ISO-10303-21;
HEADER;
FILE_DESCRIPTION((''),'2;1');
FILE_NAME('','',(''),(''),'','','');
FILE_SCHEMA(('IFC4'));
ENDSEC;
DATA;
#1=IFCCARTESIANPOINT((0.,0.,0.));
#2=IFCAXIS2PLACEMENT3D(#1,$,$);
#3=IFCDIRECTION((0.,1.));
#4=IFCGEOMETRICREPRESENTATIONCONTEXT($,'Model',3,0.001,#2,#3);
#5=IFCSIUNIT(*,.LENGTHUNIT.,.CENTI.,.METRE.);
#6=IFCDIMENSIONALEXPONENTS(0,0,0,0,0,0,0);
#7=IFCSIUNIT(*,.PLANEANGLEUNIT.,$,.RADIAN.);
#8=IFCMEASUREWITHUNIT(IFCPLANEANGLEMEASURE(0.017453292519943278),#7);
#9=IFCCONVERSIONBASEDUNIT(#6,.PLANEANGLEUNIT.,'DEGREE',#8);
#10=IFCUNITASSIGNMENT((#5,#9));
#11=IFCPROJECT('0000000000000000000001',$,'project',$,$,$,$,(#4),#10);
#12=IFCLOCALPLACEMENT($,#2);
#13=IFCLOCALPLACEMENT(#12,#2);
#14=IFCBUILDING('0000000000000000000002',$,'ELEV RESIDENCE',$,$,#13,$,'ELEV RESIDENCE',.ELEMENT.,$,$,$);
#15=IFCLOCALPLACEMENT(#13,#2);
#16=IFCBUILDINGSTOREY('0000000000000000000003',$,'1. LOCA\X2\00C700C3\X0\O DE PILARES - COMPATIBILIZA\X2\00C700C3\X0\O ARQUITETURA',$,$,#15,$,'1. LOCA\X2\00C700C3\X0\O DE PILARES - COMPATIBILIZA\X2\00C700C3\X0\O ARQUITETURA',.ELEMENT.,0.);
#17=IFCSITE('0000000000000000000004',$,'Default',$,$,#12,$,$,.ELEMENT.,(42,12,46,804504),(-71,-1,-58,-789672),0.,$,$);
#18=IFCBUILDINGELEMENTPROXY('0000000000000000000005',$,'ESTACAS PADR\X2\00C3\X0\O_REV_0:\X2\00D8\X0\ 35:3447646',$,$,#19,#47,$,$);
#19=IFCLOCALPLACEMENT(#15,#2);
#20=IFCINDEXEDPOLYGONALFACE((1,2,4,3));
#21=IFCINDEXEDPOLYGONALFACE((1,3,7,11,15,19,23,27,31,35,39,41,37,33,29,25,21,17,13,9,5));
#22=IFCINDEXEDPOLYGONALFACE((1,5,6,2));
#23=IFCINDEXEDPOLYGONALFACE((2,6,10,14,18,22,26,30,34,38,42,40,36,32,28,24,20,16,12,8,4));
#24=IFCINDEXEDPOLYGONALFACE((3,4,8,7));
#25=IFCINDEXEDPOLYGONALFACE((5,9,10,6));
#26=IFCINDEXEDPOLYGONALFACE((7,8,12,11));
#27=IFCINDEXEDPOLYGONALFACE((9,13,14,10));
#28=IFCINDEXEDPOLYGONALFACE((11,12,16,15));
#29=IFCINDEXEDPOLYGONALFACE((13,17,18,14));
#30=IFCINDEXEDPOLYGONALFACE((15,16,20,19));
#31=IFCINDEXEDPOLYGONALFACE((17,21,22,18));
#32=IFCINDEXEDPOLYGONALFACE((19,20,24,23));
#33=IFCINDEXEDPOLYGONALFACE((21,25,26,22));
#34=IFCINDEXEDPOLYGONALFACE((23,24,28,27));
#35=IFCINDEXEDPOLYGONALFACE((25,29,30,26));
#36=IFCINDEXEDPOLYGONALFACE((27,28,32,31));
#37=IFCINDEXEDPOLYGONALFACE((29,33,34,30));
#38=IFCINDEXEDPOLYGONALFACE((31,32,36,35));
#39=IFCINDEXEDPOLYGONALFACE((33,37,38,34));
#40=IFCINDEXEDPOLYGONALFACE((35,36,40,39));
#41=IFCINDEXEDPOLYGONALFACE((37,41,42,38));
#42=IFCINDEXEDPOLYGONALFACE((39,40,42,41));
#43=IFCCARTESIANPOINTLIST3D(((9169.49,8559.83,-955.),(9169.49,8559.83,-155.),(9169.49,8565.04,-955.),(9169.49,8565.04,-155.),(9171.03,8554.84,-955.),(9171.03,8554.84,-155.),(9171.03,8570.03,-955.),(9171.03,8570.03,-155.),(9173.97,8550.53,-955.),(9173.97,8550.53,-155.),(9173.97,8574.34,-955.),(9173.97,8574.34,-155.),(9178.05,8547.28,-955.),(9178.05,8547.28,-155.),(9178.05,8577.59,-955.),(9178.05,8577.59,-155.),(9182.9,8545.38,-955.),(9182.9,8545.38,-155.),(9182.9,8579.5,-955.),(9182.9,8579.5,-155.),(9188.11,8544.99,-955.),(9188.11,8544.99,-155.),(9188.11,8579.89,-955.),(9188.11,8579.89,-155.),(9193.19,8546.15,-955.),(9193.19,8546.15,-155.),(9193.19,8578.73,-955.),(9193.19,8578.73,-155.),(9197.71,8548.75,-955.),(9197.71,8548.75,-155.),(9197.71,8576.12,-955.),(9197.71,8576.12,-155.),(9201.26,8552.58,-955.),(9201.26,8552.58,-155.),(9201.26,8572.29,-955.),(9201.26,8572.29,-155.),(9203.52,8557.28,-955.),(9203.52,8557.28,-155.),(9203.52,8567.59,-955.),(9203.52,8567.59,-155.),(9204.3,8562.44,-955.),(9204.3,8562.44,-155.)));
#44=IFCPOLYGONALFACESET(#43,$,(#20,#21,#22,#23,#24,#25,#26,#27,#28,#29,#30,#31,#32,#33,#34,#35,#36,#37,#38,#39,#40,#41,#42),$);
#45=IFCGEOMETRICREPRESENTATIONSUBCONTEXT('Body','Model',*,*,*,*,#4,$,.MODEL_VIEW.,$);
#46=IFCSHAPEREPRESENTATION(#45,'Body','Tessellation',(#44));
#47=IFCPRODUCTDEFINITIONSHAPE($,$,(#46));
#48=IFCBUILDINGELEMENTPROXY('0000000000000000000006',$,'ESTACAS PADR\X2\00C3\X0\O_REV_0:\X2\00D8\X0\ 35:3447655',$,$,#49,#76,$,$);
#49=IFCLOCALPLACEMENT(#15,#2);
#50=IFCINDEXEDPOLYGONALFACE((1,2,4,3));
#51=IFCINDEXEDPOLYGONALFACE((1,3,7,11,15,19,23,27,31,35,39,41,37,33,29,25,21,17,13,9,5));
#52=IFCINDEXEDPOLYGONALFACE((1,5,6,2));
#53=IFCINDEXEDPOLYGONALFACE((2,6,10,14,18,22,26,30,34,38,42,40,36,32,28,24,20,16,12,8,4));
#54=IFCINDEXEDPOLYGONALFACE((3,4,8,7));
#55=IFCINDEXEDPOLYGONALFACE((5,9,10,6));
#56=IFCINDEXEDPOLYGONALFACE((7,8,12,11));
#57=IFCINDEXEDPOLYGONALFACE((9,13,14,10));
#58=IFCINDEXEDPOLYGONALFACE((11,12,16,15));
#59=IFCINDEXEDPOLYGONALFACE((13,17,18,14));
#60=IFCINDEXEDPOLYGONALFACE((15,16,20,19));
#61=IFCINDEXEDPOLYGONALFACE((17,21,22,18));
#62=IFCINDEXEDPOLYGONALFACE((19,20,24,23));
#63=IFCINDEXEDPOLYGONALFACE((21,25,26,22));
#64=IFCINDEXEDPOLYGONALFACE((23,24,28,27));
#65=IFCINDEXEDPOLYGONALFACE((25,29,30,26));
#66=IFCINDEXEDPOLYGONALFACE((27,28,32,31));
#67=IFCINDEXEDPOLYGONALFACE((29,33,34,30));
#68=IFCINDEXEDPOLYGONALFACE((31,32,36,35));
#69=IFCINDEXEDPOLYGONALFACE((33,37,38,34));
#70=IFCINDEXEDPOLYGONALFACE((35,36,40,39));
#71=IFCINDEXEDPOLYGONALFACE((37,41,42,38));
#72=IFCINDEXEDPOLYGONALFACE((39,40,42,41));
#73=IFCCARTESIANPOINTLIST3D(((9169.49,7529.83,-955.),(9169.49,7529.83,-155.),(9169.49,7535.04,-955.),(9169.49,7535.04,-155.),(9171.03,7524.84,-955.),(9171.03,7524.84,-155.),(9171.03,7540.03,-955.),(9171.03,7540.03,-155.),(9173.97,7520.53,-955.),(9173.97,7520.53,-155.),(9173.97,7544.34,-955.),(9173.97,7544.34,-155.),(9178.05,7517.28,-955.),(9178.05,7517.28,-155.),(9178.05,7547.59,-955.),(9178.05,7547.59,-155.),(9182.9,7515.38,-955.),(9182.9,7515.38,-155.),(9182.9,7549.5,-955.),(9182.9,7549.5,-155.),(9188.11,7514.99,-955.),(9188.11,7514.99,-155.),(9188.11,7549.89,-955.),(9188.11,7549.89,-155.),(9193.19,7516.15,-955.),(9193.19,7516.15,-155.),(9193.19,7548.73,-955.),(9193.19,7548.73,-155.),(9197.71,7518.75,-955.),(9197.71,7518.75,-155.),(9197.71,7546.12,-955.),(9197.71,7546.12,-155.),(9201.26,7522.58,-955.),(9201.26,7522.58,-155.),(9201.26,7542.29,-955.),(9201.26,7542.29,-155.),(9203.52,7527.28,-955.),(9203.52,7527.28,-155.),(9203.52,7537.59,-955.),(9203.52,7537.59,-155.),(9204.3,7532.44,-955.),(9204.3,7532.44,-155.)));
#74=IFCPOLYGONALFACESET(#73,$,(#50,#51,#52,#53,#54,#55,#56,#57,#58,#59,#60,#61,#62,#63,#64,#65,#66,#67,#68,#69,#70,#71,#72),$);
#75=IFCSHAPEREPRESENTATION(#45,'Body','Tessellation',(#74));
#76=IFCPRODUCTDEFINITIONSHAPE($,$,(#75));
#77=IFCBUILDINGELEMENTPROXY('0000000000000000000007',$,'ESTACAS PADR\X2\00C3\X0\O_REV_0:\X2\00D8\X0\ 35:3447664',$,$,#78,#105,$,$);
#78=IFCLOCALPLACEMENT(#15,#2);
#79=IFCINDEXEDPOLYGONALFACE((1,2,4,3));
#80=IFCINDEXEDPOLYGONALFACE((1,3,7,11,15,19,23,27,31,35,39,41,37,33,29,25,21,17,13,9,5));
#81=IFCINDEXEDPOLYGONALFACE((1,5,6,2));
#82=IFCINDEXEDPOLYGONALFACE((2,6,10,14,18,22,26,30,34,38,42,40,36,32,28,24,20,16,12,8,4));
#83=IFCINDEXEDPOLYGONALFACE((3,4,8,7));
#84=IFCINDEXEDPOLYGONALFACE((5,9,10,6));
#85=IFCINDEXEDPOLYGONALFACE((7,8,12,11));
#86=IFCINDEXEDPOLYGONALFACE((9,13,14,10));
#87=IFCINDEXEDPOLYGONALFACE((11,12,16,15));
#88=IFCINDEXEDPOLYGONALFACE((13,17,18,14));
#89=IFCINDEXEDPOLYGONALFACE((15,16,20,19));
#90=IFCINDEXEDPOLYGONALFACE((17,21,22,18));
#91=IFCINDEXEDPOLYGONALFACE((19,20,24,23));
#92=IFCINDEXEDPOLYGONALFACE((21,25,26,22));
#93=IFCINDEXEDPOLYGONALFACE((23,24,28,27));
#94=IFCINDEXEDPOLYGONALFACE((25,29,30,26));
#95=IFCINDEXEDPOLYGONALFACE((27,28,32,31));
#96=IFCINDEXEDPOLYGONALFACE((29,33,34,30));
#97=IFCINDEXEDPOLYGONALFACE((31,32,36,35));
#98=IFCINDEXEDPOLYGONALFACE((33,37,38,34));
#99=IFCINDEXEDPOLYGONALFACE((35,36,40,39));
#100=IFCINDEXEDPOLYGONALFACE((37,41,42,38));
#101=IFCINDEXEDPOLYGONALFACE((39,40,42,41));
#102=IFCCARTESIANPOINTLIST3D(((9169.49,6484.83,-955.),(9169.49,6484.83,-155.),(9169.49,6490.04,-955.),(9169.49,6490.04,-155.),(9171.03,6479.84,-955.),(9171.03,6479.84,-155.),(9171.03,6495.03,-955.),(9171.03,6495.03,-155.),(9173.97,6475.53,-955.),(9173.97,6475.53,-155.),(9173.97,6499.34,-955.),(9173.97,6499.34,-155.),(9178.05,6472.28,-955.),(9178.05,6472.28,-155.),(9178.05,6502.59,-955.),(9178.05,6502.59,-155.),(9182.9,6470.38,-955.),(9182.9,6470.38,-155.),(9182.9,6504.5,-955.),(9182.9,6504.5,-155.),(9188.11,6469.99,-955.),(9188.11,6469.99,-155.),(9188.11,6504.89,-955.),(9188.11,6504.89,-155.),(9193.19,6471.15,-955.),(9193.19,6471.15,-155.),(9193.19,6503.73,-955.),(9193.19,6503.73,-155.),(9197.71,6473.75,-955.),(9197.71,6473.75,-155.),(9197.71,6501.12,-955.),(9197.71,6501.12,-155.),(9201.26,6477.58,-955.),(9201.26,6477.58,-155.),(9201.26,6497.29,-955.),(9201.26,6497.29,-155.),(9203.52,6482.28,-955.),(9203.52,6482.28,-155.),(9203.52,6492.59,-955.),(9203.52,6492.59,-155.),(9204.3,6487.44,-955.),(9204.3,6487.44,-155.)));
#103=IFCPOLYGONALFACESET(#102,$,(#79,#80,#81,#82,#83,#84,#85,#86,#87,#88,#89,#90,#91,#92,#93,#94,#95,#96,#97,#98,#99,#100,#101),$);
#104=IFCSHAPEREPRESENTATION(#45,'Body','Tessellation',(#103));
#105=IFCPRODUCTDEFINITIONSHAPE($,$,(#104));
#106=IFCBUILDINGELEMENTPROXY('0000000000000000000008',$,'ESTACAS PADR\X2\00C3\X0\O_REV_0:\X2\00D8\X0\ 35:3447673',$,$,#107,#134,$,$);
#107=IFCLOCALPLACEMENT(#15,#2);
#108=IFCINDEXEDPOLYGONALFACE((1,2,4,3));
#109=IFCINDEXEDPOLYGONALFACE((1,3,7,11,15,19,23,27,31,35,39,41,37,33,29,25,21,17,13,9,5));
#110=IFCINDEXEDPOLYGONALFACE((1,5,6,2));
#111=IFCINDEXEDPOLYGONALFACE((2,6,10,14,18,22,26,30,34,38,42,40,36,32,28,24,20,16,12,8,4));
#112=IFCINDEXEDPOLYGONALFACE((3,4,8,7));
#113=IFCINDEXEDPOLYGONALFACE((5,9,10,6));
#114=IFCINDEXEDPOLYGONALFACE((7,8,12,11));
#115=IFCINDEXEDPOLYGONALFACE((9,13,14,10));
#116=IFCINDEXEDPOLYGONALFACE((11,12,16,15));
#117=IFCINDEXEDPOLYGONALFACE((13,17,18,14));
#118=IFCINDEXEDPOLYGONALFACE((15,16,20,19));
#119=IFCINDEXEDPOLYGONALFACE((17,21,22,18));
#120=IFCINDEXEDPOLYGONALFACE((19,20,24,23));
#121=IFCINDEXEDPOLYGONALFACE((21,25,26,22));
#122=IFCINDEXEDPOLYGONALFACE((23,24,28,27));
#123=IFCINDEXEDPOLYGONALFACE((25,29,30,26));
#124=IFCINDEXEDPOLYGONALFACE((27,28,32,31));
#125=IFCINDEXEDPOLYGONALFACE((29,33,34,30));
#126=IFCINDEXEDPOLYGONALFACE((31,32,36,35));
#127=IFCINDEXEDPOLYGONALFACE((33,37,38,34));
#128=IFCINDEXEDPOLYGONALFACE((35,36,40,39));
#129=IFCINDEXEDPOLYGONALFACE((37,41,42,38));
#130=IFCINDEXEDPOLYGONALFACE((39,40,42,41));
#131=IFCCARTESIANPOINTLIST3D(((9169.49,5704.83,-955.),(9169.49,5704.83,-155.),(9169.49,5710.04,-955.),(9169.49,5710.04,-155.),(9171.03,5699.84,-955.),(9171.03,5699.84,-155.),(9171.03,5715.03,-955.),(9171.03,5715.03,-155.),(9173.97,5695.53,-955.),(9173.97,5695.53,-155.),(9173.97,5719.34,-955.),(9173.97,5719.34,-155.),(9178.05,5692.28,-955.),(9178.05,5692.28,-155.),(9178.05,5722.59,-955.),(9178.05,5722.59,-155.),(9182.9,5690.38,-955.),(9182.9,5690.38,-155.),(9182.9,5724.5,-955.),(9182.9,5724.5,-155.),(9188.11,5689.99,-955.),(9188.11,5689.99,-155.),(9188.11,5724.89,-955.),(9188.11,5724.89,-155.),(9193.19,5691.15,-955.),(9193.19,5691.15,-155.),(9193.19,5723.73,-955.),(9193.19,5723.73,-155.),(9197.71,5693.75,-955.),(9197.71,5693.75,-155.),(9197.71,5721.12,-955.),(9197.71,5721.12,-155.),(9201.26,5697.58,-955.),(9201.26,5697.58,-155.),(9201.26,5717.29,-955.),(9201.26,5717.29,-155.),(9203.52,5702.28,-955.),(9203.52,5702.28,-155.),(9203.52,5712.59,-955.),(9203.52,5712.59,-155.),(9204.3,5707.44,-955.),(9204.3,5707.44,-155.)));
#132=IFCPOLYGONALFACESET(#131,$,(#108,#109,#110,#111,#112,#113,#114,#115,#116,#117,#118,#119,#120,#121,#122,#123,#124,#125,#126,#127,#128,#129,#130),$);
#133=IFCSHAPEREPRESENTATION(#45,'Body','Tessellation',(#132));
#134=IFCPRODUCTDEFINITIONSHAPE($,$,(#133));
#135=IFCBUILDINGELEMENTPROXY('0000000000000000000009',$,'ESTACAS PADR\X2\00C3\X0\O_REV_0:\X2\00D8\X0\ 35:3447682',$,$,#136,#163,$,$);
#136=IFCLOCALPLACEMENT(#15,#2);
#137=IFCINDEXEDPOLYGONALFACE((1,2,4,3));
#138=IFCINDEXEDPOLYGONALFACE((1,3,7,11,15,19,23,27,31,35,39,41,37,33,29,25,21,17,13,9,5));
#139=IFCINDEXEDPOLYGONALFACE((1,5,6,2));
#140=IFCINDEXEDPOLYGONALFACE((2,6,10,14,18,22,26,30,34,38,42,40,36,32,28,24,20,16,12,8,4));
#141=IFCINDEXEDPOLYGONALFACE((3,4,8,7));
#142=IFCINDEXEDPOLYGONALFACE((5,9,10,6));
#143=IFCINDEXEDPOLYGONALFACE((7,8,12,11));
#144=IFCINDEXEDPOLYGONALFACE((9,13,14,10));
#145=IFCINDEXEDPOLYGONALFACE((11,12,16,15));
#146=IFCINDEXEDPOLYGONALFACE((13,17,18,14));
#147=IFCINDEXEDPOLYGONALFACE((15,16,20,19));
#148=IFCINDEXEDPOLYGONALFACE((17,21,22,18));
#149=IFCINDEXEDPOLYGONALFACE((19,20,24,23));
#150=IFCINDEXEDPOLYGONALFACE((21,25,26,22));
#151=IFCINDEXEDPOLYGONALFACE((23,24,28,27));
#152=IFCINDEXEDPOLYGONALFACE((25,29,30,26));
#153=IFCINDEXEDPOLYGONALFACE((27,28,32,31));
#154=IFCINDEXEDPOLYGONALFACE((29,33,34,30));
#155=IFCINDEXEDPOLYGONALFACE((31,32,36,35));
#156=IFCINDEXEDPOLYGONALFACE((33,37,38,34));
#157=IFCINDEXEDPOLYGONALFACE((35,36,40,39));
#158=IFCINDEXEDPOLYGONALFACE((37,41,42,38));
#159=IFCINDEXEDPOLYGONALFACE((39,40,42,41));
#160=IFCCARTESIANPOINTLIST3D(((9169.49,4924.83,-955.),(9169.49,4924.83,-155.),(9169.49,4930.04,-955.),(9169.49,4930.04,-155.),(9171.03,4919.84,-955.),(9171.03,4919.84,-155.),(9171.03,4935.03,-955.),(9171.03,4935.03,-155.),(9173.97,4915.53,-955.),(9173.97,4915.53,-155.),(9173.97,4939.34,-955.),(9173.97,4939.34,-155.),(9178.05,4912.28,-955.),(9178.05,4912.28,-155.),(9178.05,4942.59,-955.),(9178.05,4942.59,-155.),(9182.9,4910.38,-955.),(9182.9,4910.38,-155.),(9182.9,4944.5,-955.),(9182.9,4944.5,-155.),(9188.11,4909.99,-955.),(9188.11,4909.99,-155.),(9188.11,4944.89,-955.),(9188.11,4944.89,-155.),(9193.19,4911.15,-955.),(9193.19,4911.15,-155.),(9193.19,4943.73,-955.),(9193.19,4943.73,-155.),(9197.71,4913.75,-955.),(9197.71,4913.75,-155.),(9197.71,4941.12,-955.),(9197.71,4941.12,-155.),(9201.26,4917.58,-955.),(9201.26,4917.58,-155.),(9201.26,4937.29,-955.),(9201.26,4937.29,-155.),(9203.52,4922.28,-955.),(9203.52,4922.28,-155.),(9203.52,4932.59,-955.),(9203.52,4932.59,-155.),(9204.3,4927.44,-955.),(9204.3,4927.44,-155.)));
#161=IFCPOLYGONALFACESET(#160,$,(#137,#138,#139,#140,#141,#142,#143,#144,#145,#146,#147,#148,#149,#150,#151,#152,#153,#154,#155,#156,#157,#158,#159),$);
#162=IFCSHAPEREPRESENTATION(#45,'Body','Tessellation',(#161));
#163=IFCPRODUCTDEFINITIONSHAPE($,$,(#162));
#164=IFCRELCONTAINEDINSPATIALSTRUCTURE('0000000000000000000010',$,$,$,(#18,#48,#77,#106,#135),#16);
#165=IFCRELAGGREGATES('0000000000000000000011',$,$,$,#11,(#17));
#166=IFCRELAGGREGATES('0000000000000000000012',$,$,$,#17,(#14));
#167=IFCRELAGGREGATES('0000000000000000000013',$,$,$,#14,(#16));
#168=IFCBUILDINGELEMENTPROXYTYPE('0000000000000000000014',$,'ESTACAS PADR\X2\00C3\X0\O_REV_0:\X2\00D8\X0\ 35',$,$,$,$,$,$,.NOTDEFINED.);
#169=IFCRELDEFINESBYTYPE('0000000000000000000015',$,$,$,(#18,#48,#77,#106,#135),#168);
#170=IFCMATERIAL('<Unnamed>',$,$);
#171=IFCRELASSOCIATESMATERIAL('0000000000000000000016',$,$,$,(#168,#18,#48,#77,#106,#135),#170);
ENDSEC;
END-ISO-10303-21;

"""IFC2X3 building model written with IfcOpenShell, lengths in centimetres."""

from ifc_helpers import new_model, entity, si_unit, converted_unit, direction, frame, frame_2d, origin, place, context, subcontext, project, spatial, circle, extrude, source, transform, mapped, material, type_object, type_shapes, element, save


model = new_model("IFC2X3")

# Units and contexts
model_context = context("Model", 3, precision=0.001, world=origin(), true_north=direction((0.0, 1.0)))
body_context = subcontext(model_context, "Body", "Model", "MODEL_VIEW")
ifc_project = project(units=[si_unit("LENGTHUNIT", "METRE", prefix="CENTI"), converted_unit("PLANEANGLEUNIT", "DEGREE", entity("IfcPlaneAngleMeasure", 0.017453292519943278), si_unit("PLANEANGLEUNIT", "RADIAN"), dimensions=[0, 0, 0, 0, 0, 0, 0])], contexts=[model_context])

# Site, building, storey
site_placement = place(None, origin())
site = spatial("IfcSite", under=ifc_project, at=site_placement, Name="Default", CompositionType="ELEMENT", RefLatitude=(42, 12, 46, 804504), RefLongitude=(-71, -1, -58, -789672), RefElevation=0.0)
building_placement = place(site_placement, origin())
building = spatial("IfcBuilding", under=site, at=building_placement, Name="ELEV RESIDENCE", LongName="ELEV RESIDENCE", CompositionType="ELEMENT")
storey_placement = place(building_placement, origin())
storey = spatial("IfcBuildingStorey", under=building, at=storey_placement, Name="1. LOCAÇÃO DE PILARES - COMPATIBILIZAÇÃO ARQUITETURA", LongName="1. LOCAÇÃO DE PILARES - COMPATIBILIZAÇÃO ARQUITETURA", CompositionType="ELEMENT", Elevation=0.0)

# Building element proxies
ifc_material_1 = material(Name="<Unnamed>")
building_element_proxy_type_1 = type_object("IfcBuildingElementProxyType", Name="ESTACAS PADRÃO_REV_0:Ø 35", PredefinedType="NOTDEFINED", material=ifc_material_1)
shared_shape_1 = source(origin(), body_context, "Body", "SweptSolid", [
    extrude(circle(Radius=17.5, at=frame_2d((0.0, 0.0), x_axis=(1.0, 0.0))), frame((0.0, 0.0, -955.0)), (0.0, 0.0, 1.0), 800.0),
])
type_shapes(building_element_proxy_type_1, [shared_shape_1])
for number, where, name in (
    (1, (9186.8, 8562.44, 0.0), "ESTACAS PADRÃO_REV_0:Ø 35:3447646"),
    (2, (9186.8, 7532.44, 0.0), "ESTACAS PADRÃO_REV_0:Ø 35:3447655"),
    (3, (9186.8, 6487.44, 0.0), "ESTACAS PADRÃO_REV_0:Ø 35:3447664"),
    (4, (9186.8, 5707.44, 0.0), "ESTACAS PADRÃO_REV_0:Ø 35:3447673"),
    (5, (9186.8, 4927.44, 0.0), "ESTACAS PADRÃO_REV_0:Ø 35:3447682"),
):
    element("IfcBuildingElementProxy", number, at=place(storey_placement, frame(where)), inside=storey, type_object=building_element_proxy_type_1, material=ifc_material_1, Name=name, context=body_context, shape_type="MappedRepresentation", body=[
        mapped(shared_shape_1, transform((0.0, 0.0, 0.0), scale=1.0)),
    ])

save(model, "model.ifc")
